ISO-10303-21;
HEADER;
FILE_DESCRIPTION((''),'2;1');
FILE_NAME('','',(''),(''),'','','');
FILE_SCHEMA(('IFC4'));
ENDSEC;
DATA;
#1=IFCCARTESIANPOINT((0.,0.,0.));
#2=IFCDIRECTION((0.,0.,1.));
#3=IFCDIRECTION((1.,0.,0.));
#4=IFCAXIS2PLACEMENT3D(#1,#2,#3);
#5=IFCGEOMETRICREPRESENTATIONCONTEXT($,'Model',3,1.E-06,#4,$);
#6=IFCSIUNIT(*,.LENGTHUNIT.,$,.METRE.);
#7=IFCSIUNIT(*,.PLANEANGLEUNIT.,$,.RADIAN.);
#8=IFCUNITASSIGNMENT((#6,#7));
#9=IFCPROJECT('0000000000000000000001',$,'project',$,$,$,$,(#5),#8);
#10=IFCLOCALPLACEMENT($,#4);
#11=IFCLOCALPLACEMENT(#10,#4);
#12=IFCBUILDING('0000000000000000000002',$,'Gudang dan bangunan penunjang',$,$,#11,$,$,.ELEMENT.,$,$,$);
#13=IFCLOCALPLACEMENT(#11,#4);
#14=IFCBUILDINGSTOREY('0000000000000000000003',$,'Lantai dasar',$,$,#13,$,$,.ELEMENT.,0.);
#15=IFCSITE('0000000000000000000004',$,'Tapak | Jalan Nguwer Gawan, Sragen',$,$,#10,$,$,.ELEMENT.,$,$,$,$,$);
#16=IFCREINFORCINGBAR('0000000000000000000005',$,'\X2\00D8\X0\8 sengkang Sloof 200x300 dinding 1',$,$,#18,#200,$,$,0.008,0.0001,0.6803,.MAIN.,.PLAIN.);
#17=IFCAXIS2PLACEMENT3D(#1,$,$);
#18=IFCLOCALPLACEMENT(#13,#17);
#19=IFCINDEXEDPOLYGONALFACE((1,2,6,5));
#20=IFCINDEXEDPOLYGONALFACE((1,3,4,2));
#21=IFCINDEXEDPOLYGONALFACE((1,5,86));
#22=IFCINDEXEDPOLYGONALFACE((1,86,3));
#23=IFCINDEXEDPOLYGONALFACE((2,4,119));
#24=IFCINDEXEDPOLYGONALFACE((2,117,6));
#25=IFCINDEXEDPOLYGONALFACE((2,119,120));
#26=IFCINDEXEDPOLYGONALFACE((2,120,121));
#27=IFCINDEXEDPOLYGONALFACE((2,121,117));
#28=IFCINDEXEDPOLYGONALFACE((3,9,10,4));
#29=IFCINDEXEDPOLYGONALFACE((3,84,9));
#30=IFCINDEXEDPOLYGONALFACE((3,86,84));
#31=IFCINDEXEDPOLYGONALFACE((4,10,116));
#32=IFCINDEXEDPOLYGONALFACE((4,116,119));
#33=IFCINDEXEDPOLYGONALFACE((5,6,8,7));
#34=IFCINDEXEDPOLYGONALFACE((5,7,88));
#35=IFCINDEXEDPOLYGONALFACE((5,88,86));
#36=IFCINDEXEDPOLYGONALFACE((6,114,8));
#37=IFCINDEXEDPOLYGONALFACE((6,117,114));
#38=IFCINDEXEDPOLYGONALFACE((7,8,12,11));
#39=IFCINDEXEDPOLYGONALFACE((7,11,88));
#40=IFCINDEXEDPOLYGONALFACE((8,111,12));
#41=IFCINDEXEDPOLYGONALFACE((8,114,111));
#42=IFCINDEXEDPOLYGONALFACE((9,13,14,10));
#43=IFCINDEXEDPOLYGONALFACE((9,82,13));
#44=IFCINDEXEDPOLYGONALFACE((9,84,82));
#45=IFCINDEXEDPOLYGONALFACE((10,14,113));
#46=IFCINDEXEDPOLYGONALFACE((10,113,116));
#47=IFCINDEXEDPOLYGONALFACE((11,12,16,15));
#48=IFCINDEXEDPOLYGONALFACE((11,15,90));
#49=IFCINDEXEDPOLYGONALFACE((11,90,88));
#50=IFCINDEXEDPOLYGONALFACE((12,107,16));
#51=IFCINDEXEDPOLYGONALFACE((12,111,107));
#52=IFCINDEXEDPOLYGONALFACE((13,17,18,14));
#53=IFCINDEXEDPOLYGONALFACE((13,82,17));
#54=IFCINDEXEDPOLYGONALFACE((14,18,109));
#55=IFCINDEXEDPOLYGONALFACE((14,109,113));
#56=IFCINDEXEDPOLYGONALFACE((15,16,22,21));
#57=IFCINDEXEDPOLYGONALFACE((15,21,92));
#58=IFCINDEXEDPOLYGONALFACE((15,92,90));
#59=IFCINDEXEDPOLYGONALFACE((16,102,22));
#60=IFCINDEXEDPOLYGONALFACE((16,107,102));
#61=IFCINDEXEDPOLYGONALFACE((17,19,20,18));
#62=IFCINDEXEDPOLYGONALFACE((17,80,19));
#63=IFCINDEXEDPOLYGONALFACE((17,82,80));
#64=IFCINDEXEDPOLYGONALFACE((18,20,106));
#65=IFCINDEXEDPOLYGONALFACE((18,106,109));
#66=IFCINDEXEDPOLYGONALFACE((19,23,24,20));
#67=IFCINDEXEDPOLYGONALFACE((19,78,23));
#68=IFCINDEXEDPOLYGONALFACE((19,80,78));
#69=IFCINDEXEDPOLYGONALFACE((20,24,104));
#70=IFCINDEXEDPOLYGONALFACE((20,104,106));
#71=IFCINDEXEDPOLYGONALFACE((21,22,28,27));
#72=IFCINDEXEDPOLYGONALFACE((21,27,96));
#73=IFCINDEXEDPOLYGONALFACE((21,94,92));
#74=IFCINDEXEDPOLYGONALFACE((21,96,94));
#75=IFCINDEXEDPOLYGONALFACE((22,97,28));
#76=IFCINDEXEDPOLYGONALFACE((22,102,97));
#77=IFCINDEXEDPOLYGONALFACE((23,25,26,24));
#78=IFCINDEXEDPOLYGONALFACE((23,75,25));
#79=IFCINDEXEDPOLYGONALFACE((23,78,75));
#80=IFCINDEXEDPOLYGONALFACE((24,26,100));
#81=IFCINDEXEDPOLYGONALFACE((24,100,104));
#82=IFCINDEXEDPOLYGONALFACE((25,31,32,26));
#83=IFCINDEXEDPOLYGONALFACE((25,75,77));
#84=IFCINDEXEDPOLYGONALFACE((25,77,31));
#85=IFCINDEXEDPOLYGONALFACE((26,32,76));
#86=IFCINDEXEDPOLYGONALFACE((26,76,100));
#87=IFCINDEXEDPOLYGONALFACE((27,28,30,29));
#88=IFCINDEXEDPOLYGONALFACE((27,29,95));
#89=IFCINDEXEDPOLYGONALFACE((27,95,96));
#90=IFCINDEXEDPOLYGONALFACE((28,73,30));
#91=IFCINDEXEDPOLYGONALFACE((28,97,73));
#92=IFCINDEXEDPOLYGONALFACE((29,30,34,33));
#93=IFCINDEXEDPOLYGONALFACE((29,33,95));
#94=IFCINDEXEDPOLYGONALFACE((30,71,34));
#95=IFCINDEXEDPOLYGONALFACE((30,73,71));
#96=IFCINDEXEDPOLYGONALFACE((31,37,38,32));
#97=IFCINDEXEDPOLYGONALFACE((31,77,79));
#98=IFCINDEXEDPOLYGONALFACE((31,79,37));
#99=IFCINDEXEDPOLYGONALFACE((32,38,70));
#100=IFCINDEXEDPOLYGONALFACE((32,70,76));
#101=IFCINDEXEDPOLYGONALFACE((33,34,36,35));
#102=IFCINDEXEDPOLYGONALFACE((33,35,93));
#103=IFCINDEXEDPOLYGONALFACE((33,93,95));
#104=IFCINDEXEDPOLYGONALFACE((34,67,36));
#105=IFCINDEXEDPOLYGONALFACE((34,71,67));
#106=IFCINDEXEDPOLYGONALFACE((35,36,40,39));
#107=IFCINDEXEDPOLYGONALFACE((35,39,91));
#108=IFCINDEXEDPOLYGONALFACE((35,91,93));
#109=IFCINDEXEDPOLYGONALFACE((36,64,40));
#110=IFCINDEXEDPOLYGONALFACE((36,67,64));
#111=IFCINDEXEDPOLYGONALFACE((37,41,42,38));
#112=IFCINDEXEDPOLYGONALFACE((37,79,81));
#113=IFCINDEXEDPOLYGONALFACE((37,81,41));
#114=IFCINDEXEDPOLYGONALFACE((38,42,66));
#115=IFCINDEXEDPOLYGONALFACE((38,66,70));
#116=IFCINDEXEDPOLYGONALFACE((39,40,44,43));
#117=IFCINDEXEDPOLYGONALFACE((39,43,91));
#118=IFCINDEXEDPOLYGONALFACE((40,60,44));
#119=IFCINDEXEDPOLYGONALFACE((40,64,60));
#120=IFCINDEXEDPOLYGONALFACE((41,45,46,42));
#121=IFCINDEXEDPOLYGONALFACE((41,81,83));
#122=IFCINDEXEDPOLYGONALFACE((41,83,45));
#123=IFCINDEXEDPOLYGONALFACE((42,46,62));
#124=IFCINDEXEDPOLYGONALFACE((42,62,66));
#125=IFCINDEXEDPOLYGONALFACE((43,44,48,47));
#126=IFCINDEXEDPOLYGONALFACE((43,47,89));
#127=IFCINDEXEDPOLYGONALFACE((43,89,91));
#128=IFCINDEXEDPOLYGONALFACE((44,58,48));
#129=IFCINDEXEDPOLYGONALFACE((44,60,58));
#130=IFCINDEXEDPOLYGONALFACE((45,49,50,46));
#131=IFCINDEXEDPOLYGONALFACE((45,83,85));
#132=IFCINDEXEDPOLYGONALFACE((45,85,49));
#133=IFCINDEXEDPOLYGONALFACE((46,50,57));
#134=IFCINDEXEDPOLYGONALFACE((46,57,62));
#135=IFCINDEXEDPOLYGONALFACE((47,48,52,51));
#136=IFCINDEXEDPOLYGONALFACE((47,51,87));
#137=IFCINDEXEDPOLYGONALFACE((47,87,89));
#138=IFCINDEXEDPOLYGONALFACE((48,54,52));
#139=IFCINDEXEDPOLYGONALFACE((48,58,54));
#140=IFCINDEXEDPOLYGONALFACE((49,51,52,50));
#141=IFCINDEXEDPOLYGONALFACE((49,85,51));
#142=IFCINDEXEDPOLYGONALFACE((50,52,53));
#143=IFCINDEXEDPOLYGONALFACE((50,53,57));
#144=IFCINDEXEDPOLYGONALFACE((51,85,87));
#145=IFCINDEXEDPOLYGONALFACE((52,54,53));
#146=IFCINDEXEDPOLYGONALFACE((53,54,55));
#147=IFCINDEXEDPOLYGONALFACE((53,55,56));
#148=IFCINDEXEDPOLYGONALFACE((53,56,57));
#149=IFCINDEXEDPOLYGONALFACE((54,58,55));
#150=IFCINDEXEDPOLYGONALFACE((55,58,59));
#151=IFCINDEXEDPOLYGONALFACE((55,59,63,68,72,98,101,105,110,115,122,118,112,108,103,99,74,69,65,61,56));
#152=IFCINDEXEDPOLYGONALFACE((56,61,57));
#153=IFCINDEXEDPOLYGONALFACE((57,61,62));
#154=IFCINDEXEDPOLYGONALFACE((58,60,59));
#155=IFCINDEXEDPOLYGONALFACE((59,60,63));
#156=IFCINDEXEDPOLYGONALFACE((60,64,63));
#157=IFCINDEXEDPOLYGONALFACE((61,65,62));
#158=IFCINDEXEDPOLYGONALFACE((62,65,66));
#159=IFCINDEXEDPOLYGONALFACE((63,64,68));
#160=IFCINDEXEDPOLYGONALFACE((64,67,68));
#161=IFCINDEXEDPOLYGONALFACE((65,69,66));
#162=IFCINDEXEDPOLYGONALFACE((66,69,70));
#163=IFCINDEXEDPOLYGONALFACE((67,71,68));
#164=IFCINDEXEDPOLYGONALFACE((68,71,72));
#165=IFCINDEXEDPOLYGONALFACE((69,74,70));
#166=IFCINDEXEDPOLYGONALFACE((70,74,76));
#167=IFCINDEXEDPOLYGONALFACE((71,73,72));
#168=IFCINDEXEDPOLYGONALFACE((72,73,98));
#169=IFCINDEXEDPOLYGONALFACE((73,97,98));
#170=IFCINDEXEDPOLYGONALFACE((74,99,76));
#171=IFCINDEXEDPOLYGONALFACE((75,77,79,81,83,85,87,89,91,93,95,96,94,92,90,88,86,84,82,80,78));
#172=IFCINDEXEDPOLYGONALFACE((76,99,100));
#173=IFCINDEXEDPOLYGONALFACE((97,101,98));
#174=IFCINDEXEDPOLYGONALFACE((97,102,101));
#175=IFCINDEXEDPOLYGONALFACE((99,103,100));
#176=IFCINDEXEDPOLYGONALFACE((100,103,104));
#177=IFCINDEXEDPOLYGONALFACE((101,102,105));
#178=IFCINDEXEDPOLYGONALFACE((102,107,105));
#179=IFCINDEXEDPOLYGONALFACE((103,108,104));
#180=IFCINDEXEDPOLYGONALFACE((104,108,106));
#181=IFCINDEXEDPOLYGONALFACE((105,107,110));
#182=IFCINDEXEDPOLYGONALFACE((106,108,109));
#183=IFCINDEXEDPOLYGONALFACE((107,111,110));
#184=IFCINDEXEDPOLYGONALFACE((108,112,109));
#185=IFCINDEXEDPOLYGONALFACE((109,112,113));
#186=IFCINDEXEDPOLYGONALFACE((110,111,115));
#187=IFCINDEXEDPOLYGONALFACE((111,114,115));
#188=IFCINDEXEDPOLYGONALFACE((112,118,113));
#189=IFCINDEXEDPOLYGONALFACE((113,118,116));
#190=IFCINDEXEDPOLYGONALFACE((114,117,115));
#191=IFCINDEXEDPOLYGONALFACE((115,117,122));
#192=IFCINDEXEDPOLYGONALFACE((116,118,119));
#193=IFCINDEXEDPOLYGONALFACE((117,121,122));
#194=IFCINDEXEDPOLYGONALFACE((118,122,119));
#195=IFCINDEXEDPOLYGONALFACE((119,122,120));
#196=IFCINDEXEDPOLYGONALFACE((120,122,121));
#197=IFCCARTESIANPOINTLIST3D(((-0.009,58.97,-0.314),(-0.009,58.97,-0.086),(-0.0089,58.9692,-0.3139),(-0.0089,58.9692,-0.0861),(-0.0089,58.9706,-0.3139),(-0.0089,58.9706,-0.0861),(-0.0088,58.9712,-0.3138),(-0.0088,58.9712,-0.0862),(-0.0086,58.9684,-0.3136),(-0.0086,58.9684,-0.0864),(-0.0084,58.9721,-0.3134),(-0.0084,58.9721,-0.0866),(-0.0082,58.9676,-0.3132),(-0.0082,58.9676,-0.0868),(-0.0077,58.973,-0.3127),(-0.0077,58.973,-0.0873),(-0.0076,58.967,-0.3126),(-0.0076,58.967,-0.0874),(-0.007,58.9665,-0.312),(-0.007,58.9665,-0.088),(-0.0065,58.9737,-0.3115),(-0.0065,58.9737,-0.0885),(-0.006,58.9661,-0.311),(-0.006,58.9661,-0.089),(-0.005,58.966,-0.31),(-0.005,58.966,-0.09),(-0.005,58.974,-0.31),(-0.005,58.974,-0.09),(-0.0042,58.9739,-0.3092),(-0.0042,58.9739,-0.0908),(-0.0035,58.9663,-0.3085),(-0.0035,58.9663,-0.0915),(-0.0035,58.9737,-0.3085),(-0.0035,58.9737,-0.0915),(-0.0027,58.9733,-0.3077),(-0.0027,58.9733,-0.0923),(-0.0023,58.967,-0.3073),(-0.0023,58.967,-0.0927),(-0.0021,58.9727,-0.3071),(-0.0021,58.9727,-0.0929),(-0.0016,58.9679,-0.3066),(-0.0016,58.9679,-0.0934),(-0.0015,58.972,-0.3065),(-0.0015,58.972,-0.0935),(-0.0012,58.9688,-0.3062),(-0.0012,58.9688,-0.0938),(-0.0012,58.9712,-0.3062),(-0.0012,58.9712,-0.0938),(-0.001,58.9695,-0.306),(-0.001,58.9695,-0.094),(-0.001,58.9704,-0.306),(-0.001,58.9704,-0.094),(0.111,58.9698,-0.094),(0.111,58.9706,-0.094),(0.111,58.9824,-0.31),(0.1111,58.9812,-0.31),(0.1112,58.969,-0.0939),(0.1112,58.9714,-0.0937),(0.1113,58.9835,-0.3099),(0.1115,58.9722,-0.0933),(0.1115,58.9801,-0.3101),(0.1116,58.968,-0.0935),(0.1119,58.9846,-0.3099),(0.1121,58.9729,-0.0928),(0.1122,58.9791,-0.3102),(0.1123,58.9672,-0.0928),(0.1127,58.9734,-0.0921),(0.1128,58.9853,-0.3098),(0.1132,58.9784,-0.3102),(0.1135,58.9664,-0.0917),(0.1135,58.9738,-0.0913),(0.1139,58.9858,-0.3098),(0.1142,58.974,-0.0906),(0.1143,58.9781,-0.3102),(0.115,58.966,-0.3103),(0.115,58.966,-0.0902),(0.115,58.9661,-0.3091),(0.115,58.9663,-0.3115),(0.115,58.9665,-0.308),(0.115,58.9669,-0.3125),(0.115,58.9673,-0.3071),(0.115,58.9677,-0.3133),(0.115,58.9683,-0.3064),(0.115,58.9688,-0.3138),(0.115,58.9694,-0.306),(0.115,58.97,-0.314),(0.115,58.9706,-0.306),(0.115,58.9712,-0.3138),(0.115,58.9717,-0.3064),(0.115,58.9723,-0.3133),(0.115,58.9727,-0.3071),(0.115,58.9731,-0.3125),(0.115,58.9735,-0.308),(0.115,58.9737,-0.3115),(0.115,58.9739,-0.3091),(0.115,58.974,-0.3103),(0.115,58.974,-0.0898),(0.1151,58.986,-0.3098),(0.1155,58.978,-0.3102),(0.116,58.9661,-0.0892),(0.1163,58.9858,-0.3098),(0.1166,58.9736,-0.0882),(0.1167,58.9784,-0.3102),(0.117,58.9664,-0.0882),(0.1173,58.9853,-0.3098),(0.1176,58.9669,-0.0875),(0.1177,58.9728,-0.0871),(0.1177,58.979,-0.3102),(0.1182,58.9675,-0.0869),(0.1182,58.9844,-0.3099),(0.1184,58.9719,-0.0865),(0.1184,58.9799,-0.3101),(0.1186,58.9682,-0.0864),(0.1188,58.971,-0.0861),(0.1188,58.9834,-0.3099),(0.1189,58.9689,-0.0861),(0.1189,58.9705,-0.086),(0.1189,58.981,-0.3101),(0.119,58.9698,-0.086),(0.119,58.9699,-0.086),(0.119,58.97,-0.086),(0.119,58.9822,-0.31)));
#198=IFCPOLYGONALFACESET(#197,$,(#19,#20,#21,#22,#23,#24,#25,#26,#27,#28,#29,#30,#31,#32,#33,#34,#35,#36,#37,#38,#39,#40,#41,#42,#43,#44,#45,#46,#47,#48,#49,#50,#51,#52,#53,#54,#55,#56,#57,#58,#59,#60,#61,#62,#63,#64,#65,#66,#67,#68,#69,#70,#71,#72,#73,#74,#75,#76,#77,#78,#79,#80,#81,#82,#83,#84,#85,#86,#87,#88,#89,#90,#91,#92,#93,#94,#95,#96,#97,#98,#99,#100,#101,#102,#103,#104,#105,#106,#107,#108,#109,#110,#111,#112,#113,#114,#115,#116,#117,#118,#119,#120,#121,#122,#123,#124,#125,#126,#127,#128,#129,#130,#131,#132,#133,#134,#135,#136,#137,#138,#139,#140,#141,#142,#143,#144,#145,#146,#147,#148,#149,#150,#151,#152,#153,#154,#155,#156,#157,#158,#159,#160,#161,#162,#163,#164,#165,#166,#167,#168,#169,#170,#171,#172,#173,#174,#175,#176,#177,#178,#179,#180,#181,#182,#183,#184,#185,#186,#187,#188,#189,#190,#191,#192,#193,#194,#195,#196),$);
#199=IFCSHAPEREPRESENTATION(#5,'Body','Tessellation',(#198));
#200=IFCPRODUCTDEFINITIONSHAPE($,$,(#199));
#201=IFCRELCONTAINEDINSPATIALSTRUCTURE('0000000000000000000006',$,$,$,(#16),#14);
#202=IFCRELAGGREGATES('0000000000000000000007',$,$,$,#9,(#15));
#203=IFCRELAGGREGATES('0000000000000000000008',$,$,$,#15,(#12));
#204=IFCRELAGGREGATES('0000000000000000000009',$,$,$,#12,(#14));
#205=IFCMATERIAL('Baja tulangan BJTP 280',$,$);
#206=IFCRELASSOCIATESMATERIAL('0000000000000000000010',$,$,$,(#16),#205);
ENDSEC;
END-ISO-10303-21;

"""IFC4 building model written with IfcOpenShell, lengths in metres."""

from ifc_helpers import new_model, entity, si_unit, origin_with_axes, place, context, project, spatial, material, element, save


model = new_model("IFC4")

# Units and contexts
model_context = context("Model", 3, precision=1e-06, world=origin_with_axes())
ifc_project = project(units=[si_unit("LENGTHUNIT", "METRE"), si_unit("PLANEANGLEUNIT", "RADIAN")], contexts=[model_context])

# Site, building, storey
site_placement = place(None, origin_with_axes())
site = spatial("IfcSite", under=ifc_project, at=site_placement, Name="Tapak | Jalan Nguwer Gawan, Sragen", CompositionType="ELEMENT")
building_placement = place(site_placement, origin_with_axes())
building = spatial("IfcBuilding", under=site, at=building_placement, Name="Gudang dan bangunan penunjang", CompositionType="ELEMENT")
storey_placement = place(building_placement, origin_with_axes())
storey = spatial("IfcBuildingStorey", under=building, at=storey_placement, Name="Lantai dasar", CompositionType="ELEMENT", Elevation=0.0)

# Shared definitions
placement = place(None, origin_with_axes())

# Reinforcing bar
ifc_material_1 = material(Name="Baja tulangan BJTP 280")
element("IfcReinforcingBar", 1, at=placement, inside=storey, material=ifc_material_1, Name="Ø8 sengkang Sloof 200x300 dinding 1", BarLength=0.6803, BarSurface="PLAIN", CrossSectionArea=0.0001, NominalDiameter=0.008, PredefinedType="MAIN", context=model_context, shape_type="AdvancedSweptSolid", body=[
    entity("IfcSweptDiskSolid", entity("IfcPolyline", [entity("IfcCartesianPoint", [0.115, 58.97, -0.31]), entity("IfcCartesianPoint", [-0.005, 58.97, -0.31]), entity("IfcCartesianPoint", [-0.005, 58.97, -0.09]), entity("IfcCartesianPoint", [0.115, 58.97, -0.09]), entity("IfcCartesianPoint", [0.115, 58.982, -0.31])]), 0.004),
])

save(model, "model.ifc")
